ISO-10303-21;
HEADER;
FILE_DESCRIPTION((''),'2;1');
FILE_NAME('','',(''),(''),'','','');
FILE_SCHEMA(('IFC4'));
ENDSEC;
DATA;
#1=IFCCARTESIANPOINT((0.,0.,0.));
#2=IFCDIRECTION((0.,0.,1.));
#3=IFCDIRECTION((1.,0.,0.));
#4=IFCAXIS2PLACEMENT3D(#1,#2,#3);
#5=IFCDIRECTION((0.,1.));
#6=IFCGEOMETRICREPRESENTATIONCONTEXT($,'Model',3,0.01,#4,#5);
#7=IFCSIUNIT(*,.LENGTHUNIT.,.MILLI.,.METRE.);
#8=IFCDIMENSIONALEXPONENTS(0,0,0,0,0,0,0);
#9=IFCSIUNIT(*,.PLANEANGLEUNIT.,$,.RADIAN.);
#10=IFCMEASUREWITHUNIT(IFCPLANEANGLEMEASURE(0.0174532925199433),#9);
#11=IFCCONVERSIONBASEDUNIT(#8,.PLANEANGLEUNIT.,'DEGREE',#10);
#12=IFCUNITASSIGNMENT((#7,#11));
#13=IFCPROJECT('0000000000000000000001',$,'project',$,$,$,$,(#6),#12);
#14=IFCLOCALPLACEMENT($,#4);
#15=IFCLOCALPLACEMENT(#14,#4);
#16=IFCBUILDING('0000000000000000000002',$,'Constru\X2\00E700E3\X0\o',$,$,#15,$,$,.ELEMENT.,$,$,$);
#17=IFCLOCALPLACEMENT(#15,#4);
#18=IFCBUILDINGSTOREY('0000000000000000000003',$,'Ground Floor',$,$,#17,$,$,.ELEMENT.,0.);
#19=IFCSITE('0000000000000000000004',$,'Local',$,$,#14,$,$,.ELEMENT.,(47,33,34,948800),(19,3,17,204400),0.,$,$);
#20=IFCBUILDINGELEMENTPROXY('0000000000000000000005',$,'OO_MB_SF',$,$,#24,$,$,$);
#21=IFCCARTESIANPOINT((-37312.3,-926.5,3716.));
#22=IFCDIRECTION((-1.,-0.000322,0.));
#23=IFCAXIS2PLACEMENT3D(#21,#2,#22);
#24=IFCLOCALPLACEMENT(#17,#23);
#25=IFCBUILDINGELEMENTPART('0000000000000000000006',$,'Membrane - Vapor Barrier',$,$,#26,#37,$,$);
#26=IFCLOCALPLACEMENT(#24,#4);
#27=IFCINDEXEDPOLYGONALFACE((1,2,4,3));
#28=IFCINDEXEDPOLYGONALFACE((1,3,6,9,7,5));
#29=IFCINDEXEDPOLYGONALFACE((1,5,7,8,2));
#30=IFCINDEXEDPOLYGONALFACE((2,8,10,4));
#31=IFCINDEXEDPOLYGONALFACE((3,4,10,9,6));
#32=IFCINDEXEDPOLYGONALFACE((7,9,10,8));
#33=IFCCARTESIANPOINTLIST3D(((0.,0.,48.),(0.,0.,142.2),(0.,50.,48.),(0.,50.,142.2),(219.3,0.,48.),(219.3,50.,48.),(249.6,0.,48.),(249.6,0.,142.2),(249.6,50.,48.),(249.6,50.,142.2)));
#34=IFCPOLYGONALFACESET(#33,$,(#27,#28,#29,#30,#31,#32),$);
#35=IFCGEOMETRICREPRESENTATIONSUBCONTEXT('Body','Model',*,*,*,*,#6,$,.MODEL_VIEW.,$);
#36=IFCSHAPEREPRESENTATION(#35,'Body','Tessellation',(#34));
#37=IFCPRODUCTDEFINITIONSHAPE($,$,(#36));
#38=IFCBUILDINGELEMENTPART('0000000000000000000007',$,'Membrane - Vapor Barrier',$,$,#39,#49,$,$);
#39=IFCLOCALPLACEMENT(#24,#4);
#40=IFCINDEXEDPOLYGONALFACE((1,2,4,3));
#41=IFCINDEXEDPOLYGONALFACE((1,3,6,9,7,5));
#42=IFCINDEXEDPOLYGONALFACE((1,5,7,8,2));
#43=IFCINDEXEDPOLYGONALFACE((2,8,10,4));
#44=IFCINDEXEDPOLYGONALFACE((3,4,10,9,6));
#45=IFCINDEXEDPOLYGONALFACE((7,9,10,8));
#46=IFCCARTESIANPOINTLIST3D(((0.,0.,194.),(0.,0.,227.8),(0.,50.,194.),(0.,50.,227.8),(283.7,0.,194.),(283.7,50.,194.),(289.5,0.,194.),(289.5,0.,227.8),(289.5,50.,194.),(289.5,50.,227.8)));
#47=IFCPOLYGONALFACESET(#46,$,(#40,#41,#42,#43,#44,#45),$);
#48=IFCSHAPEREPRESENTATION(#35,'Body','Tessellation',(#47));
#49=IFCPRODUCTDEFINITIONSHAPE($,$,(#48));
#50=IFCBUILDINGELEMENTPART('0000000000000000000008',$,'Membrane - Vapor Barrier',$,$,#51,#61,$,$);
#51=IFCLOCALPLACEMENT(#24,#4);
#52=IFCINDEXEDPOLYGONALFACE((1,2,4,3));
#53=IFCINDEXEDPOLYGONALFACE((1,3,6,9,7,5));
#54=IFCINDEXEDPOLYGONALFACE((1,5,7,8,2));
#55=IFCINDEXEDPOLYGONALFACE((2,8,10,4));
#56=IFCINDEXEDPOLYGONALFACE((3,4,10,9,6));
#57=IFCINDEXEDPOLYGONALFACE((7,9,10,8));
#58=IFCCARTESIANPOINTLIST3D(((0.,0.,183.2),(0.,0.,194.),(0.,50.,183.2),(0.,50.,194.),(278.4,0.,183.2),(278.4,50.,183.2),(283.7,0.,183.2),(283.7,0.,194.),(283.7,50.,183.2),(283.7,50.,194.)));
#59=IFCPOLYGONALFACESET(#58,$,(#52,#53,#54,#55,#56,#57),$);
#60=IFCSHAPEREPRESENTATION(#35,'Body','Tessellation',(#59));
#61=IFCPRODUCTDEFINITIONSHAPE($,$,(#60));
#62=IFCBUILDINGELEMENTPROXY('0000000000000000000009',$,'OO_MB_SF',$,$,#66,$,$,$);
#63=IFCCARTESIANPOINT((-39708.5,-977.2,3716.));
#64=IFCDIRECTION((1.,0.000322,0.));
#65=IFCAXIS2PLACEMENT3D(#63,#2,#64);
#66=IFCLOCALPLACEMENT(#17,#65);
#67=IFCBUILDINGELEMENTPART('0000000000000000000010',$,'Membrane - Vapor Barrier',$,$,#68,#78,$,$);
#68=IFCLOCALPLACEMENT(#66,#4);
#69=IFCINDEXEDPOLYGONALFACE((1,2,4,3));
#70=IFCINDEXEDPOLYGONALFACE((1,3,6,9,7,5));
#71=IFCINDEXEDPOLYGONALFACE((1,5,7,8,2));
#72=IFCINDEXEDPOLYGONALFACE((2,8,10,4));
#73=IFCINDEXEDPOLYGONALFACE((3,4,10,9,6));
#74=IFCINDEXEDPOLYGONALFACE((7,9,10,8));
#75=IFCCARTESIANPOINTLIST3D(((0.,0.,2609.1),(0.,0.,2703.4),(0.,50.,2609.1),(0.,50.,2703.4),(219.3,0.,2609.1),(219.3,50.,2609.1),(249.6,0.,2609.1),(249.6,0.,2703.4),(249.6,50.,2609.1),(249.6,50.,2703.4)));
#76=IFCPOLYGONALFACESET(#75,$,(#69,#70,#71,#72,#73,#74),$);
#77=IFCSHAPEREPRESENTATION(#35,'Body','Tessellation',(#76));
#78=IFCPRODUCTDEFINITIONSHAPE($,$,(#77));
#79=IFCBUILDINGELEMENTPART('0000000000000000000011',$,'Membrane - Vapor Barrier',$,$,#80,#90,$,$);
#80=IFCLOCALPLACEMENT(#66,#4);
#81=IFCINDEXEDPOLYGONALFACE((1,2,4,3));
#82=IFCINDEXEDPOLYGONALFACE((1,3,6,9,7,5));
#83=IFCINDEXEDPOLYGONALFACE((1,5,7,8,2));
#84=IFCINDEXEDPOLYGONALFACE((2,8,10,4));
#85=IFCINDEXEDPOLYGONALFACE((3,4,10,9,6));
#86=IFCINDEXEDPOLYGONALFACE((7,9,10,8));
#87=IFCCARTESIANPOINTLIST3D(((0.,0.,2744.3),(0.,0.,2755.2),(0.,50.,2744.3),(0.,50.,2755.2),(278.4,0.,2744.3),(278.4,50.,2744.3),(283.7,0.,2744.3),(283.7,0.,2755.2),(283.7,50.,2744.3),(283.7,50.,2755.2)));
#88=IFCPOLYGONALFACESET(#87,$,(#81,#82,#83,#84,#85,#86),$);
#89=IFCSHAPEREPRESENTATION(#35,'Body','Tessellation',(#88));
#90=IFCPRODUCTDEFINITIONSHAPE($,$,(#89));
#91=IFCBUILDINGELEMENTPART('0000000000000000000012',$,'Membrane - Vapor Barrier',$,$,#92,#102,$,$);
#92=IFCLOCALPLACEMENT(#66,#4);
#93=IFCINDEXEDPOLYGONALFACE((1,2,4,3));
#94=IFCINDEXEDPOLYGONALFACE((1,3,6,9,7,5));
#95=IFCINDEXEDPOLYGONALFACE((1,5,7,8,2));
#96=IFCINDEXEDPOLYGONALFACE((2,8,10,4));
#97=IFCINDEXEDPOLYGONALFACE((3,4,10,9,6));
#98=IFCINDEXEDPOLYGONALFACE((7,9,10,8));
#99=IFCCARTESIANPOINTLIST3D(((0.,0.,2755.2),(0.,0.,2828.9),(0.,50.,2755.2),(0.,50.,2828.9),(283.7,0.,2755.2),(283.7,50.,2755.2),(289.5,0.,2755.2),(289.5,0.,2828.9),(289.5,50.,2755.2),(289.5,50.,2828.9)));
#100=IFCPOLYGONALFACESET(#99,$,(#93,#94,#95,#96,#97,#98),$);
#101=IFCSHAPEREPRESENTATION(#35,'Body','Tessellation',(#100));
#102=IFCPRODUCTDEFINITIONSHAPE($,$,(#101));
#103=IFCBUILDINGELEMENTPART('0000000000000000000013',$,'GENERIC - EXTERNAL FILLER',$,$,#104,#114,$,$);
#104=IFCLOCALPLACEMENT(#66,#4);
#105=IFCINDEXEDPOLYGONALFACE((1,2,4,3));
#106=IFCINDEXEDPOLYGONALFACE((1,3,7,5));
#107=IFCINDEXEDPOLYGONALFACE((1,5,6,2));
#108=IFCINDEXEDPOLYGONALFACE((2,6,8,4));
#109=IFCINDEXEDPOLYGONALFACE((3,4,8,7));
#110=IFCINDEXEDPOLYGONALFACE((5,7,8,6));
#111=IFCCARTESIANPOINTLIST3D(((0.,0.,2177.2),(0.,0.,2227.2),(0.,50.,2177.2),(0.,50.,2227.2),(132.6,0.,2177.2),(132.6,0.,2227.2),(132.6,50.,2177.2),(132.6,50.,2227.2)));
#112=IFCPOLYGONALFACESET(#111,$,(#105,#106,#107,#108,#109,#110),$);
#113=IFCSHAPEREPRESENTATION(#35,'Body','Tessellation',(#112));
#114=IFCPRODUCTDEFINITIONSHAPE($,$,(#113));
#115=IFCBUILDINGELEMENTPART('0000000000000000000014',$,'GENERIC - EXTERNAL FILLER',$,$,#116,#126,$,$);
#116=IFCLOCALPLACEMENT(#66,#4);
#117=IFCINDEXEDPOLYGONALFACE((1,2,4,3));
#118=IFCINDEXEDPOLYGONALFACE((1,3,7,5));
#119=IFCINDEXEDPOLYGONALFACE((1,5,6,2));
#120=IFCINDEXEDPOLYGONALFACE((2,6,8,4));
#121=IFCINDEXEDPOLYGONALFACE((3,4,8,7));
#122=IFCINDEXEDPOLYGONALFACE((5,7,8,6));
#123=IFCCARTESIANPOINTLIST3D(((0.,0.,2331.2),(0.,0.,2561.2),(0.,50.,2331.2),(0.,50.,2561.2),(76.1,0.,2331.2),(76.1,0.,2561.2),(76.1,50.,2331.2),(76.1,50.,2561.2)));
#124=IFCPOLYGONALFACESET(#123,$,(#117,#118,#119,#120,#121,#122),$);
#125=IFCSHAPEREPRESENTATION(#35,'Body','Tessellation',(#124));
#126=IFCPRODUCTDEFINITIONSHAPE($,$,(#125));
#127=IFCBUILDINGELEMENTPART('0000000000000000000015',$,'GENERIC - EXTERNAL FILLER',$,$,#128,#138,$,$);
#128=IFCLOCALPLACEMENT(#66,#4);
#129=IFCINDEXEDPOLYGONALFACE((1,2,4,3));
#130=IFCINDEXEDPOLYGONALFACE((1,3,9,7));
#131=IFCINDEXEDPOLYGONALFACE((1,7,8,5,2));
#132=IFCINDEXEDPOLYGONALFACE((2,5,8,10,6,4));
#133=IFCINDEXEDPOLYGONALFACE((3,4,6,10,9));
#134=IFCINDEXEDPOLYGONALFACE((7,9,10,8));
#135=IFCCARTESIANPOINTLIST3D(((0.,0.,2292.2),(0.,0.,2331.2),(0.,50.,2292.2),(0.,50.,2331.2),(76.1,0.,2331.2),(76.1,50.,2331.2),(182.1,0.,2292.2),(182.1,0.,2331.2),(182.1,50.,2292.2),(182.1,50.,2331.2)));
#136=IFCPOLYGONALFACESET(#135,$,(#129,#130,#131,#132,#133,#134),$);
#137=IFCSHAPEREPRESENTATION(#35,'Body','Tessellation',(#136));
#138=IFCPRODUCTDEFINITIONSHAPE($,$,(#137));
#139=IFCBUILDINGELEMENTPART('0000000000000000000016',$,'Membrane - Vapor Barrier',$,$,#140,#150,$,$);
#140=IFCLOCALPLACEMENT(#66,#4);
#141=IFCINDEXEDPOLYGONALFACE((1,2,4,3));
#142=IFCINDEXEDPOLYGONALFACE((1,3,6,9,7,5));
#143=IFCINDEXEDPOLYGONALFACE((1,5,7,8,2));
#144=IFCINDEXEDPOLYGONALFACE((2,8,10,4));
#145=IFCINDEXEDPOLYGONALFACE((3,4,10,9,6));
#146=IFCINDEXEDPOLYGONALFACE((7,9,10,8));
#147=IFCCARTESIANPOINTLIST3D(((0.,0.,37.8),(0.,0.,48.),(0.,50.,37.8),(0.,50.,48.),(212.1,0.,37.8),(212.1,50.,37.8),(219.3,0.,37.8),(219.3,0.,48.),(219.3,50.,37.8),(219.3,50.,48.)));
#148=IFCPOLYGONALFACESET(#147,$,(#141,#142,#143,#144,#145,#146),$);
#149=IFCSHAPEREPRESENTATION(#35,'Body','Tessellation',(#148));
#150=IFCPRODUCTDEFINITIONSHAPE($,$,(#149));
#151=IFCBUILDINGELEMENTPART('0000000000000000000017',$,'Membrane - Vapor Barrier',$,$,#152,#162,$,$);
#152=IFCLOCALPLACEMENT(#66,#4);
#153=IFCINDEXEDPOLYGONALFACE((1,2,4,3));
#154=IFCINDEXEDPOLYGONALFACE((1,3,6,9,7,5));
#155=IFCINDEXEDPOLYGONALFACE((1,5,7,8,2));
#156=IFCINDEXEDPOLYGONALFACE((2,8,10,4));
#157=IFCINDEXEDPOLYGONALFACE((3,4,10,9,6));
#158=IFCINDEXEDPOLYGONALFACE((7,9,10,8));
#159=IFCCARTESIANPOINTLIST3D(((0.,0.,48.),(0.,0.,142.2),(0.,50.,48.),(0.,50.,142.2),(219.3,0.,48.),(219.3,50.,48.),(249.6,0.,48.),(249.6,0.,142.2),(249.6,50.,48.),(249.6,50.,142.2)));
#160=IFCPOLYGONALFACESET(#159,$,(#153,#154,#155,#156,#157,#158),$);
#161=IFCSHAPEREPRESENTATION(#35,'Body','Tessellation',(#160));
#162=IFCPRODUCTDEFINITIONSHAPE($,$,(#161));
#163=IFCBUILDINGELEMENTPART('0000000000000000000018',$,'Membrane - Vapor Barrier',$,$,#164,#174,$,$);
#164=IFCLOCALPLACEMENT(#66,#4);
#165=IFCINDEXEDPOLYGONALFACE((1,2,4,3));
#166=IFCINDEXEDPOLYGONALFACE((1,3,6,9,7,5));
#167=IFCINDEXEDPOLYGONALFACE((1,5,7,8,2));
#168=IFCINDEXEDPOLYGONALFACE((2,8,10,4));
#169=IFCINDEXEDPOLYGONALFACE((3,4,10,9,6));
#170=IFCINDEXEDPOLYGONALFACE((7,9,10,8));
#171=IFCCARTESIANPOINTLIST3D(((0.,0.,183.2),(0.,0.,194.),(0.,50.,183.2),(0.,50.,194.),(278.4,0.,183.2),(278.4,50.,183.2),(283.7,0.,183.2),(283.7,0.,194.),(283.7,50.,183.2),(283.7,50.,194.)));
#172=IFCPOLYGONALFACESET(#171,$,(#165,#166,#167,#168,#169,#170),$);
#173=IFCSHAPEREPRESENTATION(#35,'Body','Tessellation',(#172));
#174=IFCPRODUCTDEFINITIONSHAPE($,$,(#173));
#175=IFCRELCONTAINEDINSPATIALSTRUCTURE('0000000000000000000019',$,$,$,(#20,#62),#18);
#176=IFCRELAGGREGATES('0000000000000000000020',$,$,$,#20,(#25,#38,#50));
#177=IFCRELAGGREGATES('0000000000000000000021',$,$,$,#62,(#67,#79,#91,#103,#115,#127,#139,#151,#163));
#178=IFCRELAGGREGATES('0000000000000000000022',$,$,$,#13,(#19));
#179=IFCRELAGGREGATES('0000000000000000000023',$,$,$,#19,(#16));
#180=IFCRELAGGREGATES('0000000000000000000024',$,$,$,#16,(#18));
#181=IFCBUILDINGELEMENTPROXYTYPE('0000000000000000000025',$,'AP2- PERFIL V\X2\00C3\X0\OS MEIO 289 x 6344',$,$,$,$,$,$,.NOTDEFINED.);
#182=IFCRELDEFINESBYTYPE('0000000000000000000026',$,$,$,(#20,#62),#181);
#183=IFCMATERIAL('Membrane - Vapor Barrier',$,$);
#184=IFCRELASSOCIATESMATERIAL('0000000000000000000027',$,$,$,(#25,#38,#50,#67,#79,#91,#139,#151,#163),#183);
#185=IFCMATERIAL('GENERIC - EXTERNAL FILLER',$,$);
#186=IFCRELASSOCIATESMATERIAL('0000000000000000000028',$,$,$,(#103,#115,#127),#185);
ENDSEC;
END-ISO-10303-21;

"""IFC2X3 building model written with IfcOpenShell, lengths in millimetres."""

from ifc_helpers import new_model, entity, si_unit, converted_unit, direction, frame, origin_with_axes, place, context, subcontext, project, spatial, polyline, outline, extrude, material, type_object, element, aggregate, save


model = new_model("IFC2X3")

# Units and contexts
model_context = context("Model", 3, precision=0.01, world=origin_with_axes(), true_north=direction((0.0, 1.0)))
body_context = subcontext(model_context, "Body", "Model", "MODEL_VIEW")
ifc_project = project(units=[si_unit("LENGTHUNIT", "METRE", prefix="MILLI"), converted_unit("PLANEANGLEUNIT", "DEGREE", entity("IfcPlaneAngleMeasure", 0.0174532925199433), si_unit("PLANEANGLEUNIT", "RADIAN"), dimensions=[0, 0, 0, 0, 0, 0, 0])], contexts=[model_context])

# Site, building, storey
site_placement = place(None, origin_with_axes())
site = spatial("IfcSite", under=ifc_project, at=site_placement, Name="Local", CompositionType="ELEMENT", RefLatitude=(47, 33, 34, 948800), RefLongitude=(19, 3, 17, 204400), RefElevation=0.0)
building_placement = place(site_placement, origin_with_axes())
building = spatial("IfcBuilding", under=site, at=building_placement, Name="Construção", CompositionType="ELEMENT")
storey_placement = place(building_placement, origin_with_axes())
storey = spatial("IfcBuildingStorey", under=building, at=storey_placement, Name="Ground Floor", CompositionType="ELEMENT", Elevation=0.0)

# Shared definitions
building_element_proxy_type = type_object("IfcBuildingElementProxyType", Name="AP2- PERFIL VÃOS MEIO 289 x 6344", PredefinedType="NOTDEFINED")
ifc_material_1 = material(Name="Membrane - Vapor Barrier")

# Building element proxies, building element parts
proxy_1_placement = place(storey_placement, frame((-37312.3, -926.5, 3716.0), z_axis=(0.0, 0.0, 1.0), x_axis=(-1.0, -0.000322, 0.0)))
proxy_1 = element("IfcBuildingElementProxy", 1, at=proxy_1_placement, inside=storey, type_object=building_element_proxy_type, Name="OO_MB_SF")
ifc_material_2 = material(Name="GENERIC - EXTERNAL FILLER")
building_element_part_1_placement = place(proxy_1_placement, origin_with_axes())
building_element_part_1 = element("IfcBuildingElementPart", 2, at=building_element_part_1_placement, material=ifc_material_1, Name="Membrane - Vapor Barrier", context=body_context, shape_type="SweptSolid", body=[
    extrude(outline(polyline([(249.6, 142.2), (0.0, 142.2), (0.0, 48.0), (219.3, 48.0), (249.6, 48.0), (249.6, 142.2)])), frame((0.0, 50.0, 0.0), z_axis=(0.0, -1.0, 0.0), x_axis=(1.0, 0.0, 0.0)), (0.0, 0.0, 1.0), 50.0),
])
building_element_part_2_placement = place(proxy_1_placement, origin_with_axes())
building_element_part_2 = element("IfcBuildingElementPart", 3, at=building_element_part_2_placement, material=ifc_material_1, Name="Membrane - Vapor Barrier", context=body_context, shape_type="SweptSolid", body=[
    extrude(outline(polyline([(0.0, 194.0), (283.7, 194.0), (289.5, 194.0), (289.5, 227.8), (0.0, 227.8), (0.0, 194.0)])), frame((0.0, 50.0, 0.0), z_axis=(0.0, -1.0, 0.0), x_axis=(1.0, 0.0, 0.0)), (0.0, 0.0, 1.0), 50.0),
])
building_element_part_3_placement = place(proxy_1_placement, origin_with_axes())
building_element_part_3 = element("IfcBuildingElementPart", 4, at=building_element_part_3_placement, material=ifc_material_1, Name="Membrane - Vapor Barrier", context=body_context, shape_type="SweptSolid", body=[
    extrude(outline(polyline([(0.0, 183.2), (278.4, 183.2), (283.7, 183.2), (283.7, 194.0), (0.0, 194.0), (0.0, 183.2)])), frame((0.0, 50.0, 0.0), z_axis=(0.0, -1.0, 0.0), x_axis=(1.0, 0.0, 0.0)), (0.0, 0.0, 1.0), 50.0),
])
aggregate(proxy_1, [building_element_part_1, building_element_part_2, building_element_part_3])
proxy_2_placement = place(storey_placement, frame((-39708.5, -977.2, 3716.0), z_axis=(0.0, 0.0, 1.0), x_axis=(1.0, 0.000322, 0.0)))
proxy_2 = element("IfcBuildingElementProxy", 5, at=proxy_2_placement, inside=storey, type_object=building_element_proxy_type, Name="OO_MB_SF")
building_element_part_4_placement = place(proxy_2_placement, origin_with_axes())
building_element_part_4 = element("IfcBuildingElementPart", 6, at=building_element_part_4_placement, material=ifc_material_1, Name="Membrane - Vapor Barrier", context=body_context, shape_type="SweptSolid", body=[
    extrude(outline(polyline([(249.6, 2703.4), (0.0, 2703.4), (0.0, 2609.1), (219.3, 2609.1), (249.6, 2609.1), (249.6, 2703.4)])), frame((0.0, 50.0, 0.0), z_axis=(0.0, -1.0, 0.0), x_axis=(1.0, 0.0, 0.0)), (0.0, 0.0, 1.0), 50.0),
])
building_element_part_5_placement = place(proxy_2_placement, origin_with_axes())
building_element_part_5 = element("IfcBuildingElementPart", 7, at=building_element_part_5_placement, material=ifc_material_1, Name="Membrane - Vapor Barrier", context=body_context, shape_type="SweptSolid", body=[
    extrude(outline(polyline([(0.0, 2744.3), (278.4, 2744.3), (283.7, 2744.3), (283.7, 2755.2), (0.0, 2755.2), (0.0, 2744.3)])), frame((0.0, 50.0, 0.0), z_axis=(0.0, -1.0, 0.0), x_axis=(1.0, 0.0, 0.0)), (0.0, 0.0, 1.0), 50.0),
])
building_element_part_6_placement = place(proxy_2_placement, origin_with_axes())
building_element_part_6 = element("IfcBuildingElementPart", 8, at=building_element_part_6_placement, material=ifc_material_1, Name="Membrane - Vapor Barrier", context=body_context, shape_type="SweptSolid", body=[
    extrude(outline(polyline([(0.0, 2755.2), (283.7, 2755.2), (289.5, 2755.2), (289.5, 2828.9), (0.0, 2828.9), (0.0, 2755.2)])), frame((0.0, 50.0, 0.0), z_axis=(0.0, -1.0, 0.0), x_axis=(1.0, 0.0, 0.0)), (0.0, 0.0, 1.0), 50.0),
])
building_element_part_7_placement = place(proxy_2_placement, origin_with_axes())
building_element_part_7 = element("IfcBuildingElementPart", 9, at=building_element_part_7_placement, material=ifc_material_2, Name="GENERIC - EXTERNAL FILLER", context=body_context, shape_type="SweptSolid", body=[
    extrude(outline(polyline([(0.0, 2227.2), (0.0, 2177.2), (132.6, 2177.2), (132.6, 2227.2), (0.0, 2227.2)])), frame((0.0, 50.0, 0.0), z_axis=(0.0, -1.0, 0.0), x_axis=(1.0, 0.0, 0.0)), (0.0, 0.0, 1.0), 50.0),
])
building_element_part_8_placement = place(proxy_2_placement, origin_with_axes())
building_element_part_8 = element("IfcBuildingElementPart", 10, at=building_element_part_8_placement, material=ifc_material_2, Name="GENERIC - EXTERNAL FILLER", context=body_context, shape_type="SweptSolid", body=[
    extrude(outline(polyline([(76.1, 2561.2), (0.0, 2561.2), (0.0, 2331.2), (76.1, 2331.2), (76.1, 2561.2)])), frame((0.0, 50.0, 0.0), z_axis=(0.0, -1.0, 0.0), x_axis=(1.0, 0.0, 0.0)), (0.0, 0.0, 1.0), 50.0),
])
building_element_part_9_placement = place(proxy_2_placement, origin_with_axes())
building_element_part_9 = element("IfcBuildingElementPart", 11, at=building_element_part_9_placement, material=ifc_material_2, Name="GENERIC - EXTERNAL FILLER", context=body_context, shape_type="SweptSolid", body=[
    extrude(outline(polyline([(0.0, 2331.2), (0.0, 2292.2), (182.1, 2292.2), (182.1, 2331.2), (76.1, 2331.2), (0.0, 2331.2)])), frame((0.0, 50.0, 0.0), z_axis=(0.0, -1.0, 0.0), x_axis=(1.0, 0.0, 0.0)), (0.0, 0.0, 1.0), 50.0),
])
building_element_part_10_placement = place(proxy_2_placement, origin_with_axes())
building_element_part_10 = element("IfcBuildingElementPart", 12, at=building_element_part_10_placement, material=ifc_material_1, Name="Membrane - Vapor Barrier", context=body_context, shape_type="SweptSolid", body=[
    extrude(outline(polyline([(0.0, 37.8), (212.1, 37.8), (219.3, 37.8), (219.3, 48.0), (0.0, 48.0), (0.0, 37.8)])), frame((0.0, 50.0, 0.0), z_axis=(0.0, -1.0, 0.0), x_axis=(1.0, 0.0, 0.0)), (0.0, 0.0, 1.0), 50.0),
])
building_element_part_11_placement = place(proxy_2_placement, origin_with_axes())
building_element_part_11 = element("IfcBuildingElementPart", 13, at=building_element_part_11_placement, material=ifc_material_1, Name="Membrane - Vapor Barrier", context=body_context, shape_type="SweptSolid", body=[
    extrude(outline(polyline([(249.6, 142.2), (0.0, 142.2), (0.0, 48.0), (219.3, 48.0), (249.6, 48.0), (249.6, 142.2)])), frame((0.0, 50.0, 0.0), z_axis=(0.0, -1.0, 0.0), x_axis=(1.0, 0.0, 0.0)), (0.0, 0.0, 1.0), 50.0),
])
building_element_part_12_placement = place(proxy_2_placement, origin_with_axes())
building_element_part_12 = element("IfcBuildingElementPart", 14, at=building_element_part_12_placement, material=ifc_material_1, Name="Membrane - Vapor Barrier", context=body_context, shape_type="SweptSolid", body=[
    extrude(outline(polyline([(0.0, 183.2), (278.4, 183.2), (283.7, 183.2), (283.7, 194.0), (0.0, 194.0), (0.0, 183.2)])), frame((0.0, 50.0, 0.0), z_axis=(0.0, -1.0, 0.0), x_axis=(1.0, 0.0, 0.0)), (0.0, 0.0, 1.0), 50.0),
])
aggregate(proxy_2, [building_element_part_4, building_element_part_5, building_element_part_6, building_element_part_7, building_element_part_8, building_element_part_9, building_element_part_10, building_element_part_11, building_element_part_12])

save(model, "model.ifc")
